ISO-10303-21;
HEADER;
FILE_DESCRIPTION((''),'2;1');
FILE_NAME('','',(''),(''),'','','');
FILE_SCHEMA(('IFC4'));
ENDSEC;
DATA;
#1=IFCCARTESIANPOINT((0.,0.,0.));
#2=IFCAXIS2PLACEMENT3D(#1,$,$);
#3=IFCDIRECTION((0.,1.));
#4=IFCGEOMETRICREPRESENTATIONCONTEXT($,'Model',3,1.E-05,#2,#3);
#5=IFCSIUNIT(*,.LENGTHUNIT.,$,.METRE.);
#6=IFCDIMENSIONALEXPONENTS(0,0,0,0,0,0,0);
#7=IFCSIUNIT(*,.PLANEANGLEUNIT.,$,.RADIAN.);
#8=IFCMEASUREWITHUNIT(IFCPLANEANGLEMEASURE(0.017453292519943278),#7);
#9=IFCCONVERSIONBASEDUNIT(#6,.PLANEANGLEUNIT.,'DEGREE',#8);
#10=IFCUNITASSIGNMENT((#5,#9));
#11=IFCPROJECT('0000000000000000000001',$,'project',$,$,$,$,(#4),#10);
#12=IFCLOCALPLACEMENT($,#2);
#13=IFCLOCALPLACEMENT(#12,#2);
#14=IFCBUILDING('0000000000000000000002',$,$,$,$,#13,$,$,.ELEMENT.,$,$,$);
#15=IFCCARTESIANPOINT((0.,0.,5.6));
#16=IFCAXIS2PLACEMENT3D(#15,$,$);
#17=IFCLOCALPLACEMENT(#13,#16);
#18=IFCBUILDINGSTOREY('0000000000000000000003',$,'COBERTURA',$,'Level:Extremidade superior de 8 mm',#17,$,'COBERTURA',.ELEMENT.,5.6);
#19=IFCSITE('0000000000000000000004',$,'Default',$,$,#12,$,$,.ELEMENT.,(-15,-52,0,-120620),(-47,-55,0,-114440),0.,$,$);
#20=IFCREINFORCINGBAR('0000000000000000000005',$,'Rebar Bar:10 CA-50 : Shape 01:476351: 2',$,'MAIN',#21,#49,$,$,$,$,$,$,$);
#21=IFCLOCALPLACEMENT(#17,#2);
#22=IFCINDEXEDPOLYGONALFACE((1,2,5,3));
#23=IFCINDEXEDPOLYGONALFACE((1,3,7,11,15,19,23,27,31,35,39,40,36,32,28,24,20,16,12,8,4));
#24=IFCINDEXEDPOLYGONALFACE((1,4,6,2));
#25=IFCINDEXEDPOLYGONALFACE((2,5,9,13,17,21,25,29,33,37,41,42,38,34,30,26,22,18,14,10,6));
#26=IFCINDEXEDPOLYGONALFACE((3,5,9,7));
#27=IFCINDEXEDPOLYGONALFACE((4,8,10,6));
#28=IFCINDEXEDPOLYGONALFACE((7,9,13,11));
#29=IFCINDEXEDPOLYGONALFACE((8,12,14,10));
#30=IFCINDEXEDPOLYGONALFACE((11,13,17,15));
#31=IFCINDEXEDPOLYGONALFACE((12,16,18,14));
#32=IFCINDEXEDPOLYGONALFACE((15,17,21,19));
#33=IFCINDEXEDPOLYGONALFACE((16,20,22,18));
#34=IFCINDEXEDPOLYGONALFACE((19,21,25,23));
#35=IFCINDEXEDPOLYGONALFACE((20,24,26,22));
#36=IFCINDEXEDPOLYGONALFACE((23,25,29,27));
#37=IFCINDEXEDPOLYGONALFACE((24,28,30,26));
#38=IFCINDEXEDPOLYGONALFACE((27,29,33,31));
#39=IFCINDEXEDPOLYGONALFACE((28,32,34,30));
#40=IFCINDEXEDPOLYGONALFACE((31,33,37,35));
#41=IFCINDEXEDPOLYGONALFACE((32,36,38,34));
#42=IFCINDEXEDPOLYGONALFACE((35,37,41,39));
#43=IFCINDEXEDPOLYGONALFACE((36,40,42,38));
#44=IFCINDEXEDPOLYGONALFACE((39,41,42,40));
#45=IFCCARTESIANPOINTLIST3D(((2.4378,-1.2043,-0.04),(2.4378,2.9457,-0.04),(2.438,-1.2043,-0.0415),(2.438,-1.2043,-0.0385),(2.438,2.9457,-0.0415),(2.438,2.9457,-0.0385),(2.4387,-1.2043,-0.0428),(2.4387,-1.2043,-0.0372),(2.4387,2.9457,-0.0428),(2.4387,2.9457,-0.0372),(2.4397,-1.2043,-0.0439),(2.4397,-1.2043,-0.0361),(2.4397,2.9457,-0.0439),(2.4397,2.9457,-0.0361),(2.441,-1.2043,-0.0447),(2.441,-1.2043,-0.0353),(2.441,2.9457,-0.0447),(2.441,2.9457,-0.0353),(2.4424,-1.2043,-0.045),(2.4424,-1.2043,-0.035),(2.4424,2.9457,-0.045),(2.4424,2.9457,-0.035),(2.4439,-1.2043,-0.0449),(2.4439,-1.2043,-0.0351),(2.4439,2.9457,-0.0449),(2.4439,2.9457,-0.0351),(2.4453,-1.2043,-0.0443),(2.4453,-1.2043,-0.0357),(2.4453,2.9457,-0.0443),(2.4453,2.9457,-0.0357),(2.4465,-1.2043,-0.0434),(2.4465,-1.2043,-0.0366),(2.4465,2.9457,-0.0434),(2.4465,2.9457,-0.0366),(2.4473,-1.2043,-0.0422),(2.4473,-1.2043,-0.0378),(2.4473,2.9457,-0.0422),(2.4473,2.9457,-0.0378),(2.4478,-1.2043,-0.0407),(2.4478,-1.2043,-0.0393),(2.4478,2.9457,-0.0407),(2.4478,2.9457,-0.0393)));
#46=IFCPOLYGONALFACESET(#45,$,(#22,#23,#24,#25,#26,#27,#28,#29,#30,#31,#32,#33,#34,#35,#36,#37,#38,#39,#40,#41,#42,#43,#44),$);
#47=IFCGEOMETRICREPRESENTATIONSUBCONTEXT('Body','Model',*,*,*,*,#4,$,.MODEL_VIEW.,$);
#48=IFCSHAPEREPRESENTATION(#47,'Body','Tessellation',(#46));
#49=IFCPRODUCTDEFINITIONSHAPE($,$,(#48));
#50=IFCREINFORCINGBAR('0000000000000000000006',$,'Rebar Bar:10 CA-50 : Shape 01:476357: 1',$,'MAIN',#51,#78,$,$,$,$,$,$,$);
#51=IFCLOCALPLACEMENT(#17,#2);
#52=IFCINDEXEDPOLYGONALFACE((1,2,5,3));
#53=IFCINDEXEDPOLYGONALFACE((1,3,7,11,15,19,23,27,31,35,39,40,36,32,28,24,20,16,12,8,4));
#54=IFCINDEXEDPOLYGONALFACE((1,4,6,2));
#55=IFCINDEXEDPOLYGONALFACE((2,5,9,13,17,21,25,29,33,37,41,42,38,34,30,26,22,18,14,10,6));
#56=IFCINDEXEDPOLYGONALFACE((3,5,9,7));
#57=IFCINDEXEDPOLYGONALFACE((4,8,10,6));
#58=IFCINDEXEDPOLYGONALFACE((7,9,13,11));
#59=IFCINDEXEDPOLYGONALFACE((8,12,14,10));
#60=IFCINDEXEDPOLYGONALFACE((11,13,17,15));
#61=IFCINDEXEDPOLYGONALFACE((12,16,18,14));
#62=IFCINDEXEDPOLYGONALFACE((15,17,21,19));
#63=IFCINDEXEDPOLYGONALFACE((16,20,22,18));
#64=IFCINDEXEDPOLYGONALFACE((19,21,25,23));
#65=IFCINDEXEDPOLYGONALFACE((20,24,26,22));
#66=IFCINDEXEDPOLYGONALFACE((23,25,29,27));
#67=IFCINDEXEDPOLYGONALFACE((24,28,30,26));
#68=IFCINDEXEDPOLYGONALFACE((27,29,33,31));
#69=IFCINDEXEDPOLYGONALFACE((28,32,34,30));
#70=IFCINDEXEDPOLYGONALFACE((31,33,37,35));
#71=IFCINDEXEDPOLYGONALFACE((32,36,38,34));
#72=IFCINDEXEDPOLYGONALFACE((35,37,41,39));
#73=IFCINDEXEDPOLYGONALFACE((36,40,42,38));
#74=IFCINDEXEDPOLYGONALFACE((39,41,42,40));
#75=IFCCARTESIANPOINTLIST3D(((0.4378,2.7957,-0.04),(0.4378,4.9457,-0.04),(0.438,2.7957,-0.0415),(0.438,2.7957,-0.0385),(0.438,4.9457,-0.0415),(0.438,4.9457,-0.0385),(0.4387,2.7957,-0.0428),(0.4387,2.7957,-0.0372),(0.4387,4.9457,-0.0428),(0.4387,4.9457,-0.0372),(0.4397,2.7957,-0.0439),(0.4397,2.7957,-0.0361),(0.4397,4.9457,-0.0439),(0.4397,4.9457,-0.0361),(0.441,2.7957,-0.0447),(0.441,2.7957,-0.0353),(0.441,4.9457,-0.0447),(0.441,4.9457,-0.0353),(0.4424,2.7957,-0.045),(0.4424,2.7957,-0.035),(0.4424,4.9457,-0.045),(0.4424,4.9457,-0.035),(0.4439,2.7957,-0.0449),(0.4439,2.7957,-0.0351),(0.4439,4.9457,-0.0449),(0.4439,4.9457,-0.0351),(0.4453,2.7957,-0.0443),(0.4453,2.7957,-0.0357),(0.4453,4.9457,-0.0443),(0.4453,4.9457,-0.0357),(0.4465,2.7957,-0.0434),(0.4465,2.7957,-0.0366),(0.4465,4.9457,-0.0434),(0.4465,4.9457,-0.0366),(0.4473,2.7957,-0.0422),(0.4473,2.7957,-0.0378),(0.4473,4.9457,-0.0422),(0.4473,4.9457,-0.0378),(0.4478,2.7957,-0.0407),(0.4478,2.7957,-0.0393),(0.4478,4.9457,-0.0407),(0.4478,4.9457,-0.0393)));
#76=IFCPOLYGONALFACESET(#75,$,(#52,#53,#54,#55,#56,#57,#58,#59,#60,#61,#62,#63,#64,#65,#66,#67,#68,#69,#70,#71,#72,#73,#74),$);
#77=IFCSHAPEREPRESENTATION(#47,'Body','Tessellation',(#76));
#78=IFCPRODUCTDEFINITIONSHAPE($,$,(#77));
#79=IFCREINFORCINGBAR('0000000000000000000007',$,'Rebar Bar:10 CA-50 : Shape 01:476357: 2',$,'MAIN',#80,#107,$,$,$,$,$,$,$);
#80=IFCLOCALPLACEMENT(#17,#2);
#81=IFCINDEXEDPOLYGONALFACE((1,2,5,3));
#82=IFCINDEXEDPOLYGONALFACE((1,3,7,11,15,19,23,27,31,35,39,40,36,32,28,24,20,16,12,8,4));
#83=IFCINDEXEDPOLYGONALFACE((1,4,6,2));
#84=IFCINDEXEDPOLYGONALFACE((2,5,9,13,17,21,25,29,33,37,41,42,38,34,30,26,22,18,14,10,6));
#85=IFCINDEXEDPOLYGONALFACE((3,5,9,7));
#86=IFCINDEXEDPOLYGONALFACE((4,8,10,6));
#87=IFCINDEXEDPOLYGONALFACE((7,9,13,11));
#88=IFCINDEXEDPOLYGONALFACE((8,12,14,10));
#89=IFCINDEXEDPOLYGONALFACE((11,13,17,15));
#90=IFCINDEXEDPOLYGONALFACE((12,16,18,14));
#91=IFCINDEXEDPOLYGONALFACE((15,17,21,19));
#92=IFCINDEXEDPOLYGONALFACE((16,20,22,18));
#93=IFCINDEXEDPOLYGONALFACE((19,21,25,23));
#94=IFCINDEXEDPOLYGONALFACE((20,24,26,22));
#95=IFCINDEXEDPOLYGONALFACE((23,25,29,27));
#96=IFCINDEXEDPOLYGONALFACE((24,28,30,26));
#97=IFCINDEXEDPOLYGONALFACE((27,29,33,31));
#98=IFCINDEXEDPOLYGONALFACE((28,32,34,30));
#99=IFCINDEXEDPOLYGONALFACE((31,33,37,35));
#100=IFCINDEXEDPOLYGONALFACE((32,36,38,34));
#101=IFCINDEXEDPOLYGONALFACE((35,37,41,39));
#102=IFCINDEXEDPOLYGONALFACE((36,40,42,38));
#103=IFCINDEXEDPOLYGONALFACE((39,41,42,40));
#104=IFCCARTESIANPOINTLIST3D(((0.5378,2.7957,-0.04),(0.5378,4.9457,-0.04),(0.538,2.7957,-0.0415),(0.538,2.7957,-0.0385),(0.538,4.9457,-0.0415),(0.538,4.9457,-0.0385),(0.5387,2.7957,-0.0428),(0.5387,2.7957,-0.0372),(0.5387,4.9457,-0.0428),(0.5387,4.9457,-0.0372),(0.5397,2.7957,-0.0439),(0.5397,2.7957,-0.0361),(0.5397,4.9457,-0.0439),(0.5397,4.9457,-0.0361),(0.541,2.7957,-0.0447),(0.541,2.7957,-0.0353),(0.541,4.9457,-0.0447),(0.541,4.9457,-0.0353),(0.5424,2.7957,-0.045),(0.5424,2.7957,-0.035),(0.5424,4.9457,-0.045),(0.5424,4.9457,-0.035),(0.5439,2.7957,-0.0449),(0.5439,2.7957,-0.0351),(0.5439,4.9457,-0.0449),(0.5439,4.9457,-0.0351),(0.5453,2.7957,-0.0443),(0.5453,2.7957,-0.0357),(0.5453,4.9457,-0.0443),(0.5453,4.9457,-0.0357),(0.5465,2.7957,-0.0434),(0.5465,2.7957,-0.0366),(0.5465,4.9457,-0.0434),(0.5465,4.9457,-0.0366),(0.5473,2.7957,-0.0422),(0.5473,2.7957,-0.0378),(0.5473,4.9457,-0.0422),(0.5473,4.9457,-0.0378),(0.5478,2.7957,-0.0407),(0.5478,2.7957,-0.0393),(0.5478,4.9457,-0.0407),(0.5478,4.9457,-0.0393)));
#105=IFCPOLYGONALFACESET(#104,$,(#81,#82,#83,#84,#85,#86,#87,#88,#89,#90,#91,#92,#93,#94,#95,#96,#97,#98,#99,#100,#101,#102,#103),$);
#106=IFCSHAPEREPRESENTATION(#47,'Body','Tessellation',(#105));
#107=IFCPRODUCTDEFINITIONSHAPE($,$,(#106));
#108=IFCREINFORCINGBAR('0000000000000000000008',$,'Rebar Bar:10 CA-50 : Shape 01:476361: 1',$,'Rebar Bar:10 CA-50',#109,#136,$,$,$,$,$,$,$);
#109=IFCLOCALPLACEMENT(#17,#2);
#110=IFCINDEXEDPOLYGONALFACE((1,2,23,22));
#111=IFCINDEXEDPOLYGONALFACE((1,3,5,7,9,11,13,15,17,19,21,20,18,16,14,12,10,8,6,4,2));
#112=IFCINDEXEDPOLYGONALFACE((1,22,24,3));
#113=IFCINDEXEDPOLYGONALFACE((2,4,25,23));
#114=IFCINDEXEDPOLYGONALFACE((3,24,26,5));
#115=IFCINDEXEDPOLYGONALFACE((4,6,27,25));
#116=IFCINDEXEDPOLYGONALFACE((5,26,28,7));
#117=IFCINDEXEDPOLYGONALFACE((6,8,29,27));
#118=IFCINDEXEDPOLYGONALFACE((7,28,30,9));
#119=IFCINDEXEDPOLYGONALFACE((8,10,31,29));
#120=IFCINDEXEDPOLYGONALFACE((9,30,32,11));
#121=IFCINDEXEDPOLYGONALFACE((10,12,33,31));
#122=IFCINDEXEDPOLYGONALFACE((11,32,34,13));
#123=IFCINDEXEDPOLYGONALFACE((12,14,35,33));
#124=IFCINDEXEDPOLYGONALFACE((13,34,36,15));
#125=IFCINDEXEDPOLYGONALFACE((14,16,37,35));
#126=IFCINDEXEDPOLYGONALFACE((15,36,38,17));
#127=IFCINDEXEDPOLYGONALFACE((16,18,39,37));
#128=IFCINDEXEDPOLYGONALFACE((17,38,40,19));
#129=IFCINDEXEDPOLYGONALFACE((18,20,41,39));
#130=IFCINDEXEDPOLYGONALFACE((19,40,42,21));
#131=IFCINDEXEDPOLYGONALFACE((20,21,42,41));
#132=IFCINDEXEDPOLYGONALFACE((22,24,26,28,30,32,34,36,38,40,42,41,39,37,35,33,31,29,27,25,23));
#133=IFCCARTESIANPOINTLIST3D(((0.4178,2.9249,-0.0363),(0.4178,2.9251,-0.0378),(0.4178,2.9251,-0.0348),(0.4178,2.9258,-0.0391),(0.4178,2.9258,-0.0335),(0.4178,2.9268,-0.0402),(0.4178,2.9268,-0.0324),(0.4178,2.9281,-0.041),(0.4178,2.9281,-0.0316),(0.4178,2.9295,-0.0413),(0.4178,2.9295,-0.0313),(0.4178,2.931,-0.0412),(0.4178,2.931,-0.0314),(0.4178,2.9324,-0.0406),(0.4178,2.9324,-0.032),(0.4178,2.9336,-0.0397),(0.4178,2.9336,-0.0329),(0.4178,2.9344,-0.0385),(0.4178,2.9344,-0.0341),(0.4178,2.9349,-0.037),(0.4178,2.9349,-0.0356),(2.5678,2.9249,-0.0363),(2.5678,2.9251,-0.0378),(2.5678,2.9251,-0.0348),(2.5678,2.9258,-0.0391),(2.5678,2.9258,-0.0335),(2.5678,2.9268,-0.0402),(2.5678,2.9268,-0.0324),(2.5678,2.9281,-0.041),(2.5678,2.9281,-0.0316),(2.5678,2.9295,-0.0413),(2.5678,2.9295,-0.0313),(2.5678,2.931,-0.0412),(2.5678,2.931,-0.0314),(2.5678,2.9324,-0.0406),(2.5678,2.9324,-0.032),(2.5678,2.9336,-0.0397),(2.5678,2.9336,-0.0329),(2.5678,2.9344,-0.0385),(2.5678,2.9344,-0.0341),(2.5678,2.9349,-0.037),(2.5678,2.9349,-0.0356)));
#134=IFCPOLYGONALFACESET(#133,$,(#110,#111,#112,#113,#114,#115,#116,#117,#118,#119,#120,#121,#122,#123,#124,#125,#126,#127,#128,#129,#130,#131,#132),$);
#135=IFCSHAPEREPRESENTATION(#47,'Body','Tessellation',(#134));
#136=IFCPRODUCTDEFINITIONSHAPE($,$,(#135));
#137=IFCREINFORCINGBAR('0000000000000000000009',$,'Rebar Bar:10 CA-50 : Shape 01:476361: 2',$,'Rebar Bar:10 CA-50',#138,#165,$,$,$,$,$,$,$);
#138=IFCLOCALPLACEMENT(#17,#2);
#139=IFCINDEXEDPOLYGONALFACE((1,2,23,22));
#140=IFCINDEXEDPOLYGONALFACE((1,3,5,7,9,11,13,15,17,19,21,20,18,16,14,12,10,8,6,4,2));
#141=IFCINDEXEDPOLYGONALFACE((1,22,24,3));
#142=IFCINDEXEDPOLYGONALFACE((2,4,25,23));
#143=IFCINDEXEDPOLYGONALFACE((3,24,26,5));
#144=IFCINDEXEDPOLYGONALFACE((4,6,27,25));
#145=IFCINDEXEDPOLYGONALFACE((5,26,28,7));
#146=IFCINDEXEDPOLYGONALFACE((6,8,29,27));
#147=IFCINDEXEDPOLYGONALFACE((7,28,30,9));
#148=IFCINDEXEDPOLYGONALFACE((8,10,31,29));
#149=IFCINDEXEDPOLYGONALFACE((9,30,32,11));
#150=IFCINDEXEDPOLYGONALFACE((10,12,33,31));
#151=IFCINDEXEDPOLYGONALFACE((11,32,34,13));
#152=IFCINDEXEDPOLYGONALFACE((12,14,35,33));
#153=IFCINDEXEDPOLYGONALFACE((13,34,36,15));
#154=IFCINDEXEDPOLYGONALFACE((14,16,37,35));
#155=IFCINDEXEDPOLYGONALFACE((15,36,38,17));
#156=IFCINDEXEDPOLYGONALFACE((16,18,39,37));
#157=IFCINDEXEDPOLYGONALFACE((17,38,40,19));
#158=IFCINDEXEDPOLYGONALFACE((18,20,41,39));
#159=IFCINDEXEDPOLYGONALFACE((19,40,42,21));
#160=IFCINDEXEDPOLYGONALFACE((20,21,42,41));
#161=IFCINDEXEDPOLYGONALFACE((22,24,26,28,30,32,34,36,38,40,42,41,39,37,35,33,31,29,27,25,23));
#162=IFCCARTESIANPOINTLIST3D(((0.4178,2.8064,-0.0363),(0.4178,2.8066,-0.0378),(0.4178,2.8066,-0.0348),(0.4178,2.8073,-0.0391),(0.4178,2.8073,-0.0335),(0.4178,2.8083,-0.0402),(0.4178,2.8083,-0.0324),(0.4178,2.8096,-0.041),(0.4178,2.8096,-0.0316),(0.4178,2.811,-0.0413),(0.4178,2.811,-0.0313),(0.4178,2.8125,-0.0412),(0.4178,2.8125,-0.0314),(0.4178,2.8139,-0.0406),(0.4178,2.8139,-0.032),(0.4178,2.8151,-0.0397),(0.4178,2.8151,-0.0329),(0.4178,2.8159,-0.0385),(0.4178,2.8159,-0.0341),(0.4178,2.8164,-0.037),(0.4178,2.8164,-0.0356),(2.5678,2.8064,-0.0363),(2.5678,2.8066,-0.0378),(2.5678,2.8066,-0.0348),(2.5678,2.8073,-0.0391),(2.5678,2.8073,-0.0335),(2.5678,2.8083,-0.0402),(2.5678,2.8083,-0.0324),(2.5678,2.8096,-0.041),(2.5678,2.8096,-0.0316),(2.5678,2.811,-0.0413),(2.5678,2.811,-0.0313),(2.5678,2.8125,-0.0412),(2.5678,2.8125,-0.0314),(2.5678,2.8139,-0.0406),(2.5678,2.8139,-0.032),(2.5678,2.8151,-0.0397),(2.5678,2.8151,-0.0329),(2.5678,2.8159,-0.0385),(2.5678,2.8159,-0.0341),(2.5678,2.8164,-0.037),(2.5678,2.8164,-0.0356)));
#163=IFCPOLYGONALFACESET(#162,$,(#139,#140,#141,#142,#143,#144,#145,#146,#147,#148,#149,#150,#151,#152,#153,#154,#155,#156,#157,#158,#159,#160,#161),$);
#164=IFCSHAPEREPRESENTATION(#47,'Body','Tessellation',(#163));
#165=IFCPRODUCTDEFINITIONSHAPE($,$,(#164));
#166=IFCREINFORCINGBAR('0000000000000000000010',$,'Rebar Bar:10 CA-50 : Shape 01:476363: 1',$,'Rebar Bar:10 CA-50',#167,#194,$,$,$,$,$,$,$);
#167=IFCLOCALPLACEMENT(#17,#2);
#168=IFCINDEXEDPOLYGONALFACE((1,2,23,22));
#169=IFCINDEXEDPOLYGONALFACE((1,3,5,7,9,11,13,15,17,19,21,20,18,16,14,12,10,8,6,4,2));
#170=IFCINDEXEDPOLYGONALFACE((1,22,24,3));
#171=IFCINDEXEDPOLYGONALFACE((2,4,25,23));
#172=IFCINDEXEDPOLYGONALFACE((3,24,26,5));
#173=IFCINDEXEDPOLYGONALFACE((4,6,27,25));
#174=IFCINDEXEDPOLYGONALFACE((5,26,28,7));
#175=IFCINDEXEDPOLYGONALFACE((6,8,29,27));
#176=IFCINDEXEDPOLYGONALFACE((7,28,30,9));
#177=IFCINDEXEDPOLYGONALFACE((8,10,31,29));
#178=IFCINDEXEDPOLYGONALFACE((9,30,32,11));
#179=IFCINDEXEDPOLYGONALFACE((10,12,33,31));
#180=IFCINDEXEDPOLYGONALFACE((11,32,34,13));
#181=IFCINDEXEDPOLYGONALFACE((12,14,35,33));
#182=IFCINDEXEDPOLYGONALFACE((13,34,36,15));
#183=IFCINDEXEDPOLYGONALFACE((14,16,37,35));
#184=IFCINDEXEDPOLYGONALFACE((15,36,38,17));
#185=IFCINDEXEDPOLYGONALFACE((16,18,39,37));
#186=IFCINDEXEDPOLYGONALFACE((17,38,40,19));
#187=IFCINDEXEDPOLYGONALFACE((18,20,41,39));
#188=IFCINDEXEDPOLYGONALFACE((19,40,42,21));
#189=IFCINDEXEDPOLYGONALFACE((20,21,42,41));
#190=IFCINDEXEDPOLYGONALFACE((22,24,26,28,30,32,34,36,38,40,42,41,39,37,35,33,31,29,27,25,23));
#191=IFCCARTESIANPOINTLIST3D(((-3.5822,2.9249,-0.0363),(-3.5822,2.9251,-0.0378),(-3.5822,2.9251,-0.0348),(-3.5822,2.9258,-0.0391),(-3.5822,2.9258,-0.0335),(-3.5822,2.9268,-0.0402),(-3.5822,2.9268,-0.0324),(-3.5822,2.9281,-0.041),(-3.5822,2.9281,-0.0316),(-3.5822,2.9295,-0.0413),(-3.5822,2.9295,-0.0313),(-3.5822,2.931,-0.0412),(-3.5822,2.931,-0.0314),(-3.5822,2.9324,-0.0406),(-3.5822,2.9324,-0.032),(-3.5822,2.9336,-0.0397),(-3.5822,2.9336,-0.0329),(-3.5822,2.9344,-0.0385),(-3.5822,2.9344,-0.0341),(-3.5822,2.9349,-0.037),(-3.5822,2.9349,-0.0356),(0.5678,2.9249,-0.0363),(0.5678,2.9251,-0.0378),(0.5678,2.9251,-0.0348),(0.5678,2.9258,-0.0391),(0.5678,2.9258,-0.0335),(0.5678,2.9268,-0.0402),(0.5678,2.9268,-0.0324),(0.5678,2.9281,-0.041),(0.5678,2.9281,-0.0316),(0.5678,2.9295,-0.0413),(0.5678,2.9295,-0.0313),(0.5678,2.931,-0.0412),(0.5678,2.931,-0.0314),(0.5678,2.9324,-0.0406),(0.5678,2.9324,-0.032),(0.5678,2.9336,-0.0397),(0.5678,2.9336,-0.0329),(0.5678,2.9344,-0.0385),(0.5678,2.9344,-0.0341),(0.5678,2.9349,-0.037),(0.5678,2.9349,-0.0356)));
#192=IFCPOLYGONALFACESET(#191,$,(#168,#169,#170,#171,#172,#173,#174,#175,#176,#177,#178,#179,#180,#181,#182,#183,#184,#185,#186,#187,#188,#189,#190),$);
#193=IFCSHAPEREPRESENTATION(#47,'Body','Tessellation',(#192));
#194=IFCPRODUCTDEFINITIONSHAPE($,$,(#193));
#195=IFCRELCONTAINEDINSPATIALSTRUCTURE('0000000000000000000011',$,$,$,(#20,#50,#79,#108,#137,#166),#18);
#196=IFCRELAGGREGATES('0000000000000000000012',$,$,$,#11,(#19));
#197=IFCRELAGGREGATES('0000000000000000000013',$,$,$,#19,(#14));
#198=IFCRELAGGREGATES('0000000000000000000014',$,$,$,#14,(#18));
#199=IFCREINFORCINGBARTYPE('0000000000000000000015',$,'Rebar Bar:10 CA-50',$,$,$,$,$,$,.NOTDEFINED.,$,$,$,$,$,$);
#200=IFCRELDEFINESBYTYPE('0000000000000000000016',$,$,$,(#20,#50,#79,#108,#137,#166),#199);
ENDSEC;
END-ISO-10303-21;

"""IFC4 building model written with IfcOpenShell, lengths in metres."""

from ifc_helpers import new_model, entity, si_unit, converted_unit, direction, frame, origin, place, context, subcontext, project, spatial, type_object, element, save


model = new_model("IFC4")

# Units and contexts
model_context = context("Model", 3, precision=1e-05, world=origin(), true_north=direction((0.0, 1.0)))
body_context = subcontext(model_context, "Body", "Model", "MODEL_VIEW")
ifc_project = project(units=[si_unit("LENGTHUNIT", "METRE"), converted_unit("PLANEANGLEUNIT", "DEGREE", entity("IfcPlaneAngleMeasure", 0.017453292519943278), si_unit("PLANEANGLEUNIT", "RADIAN"), dimensions=[0, 0, 0, 0, 0, 0, 0])], contexts=[model_context])

# Site, building, storey
site_placement = place(None, origin())
site = spatial("IfcSite", under=ifc_project, at=site_placement, Name="Default", CompositionType="ELEMENT", RefLatitude=(-15, -52, 0, -120620), RefLongitude=(-47, -55, 0, -114440), RefElevation=0.0)
building_placement = place(site_placement, origin())
building = spatial("IfcBuilding", under=site, at=building_placement, CompositionType="ELEMENT")
storey_placement = place(building_placement, frame((0.0, 0.0, 5.6)))
storey = spatial("IfcBuildingStorey", under=building, at=storey_placement, Name="COBERTURA", ObjectType="Level:Extremidade superior de 8 mm", LongName="COBERTURA", CompositionType="ELEMENT", Elevation=5.6)

# Reinforcing bars
reinforcing_bar_type = type_object("IfcReinforcingBarType", Name="Rebar Bar:10 CA-50", PredefinedType="NOTDEFINED")
reinforcing_bar_1_placement = place(storey_placement, origin())
element("IfcReinforcingBar", 1, at=reinforcing_bar_1_placement, inside=storey, type_object=reinforcing_bar_type, Name="Rebar Bar:10 CA-50 : Shape 01:476351: 2", ObjectType="MAIN", context=body_context, shape_type="AdvancedSweptSolid", body=[
    entity("IfcSweptDiskSolid", entity("IfcIndexedPolyCurve", entity("IfcCartesianPointList3D", [[2.4428, 2.9457, -0.04], [2.4428, -1.2043, -0.04]]), None, False), 0.005, None, 0.0, 1.0),
])
reinforcing_bar_2_placement = place(storey_placement, origin())
element("IfcReinforcingBar", 2, at=reinforcing_bar_2_placement, inside=storey, type_object=reinforcing_bar_type, Name="Rebar Bar:10 CA-50 : Shape 01:476357: 1", ObjectType="MAIN", context=body_context, shape_type="AdvancedSweptSolid", body=[
    entity("IfcSweptDiskSolid", entity("IfcIndexedPolyCurve", entity("IfcCartesianPointList3D", [[0.4428, 4.9457, -0.04], [0.4428, 2.7957, -0.04]]), None, False), 0.005, None, 0.0, 1.0),
])
reinforcing_bar_3_placement = place(storey_placement, origin())
element("IfcReinforcingBar", 3, at=reinforcing_bar_3_placement, inside=storey, type_object=reinforcing_bar_type, Name="Rebar Bar:10 CA-50 : Shape 01:476357: 2", ObjectType="MAIN", context=body_context, shape_type="AdvancedSweptSolid", body=[
    entity("IfcSweptDiskSolid", entity("IfcIndexedPolyCurve", entity("IfcCartesianPointList3D", [[0.5428, 4.9457, -0.04], [0.5428, 2.7957, -0.04]]), None, False), 0.005, None, 0.0, 1.0),
])
reinforcing_bar_4_placement = place(storey_placement, origin())
element("IfcReinforcingBar", 4, at=reinforcing_bar_4_placement, inside=storey, type_object=reinforcing_bar_type, Name="Rebar Bar:10 CA-50 : Shape 01:476361: 1", ObjectType="Rebar Bar:10 CA-50", context=body_context, shape_type="AdvancedSweptSolid", body=[
    entity("IfcSweptDiskSolid", entity("IfcIndexedPolyCurve", entity("IfcCartesianPointList3D", [[2.5678, 2.9299, -0.0363], [0.4178, 2.9299, -0.0363]]), None, False), 0.005, None, 0.0, 1.0),
])
reinforcing_bar_5_placement = place(storey_placement, origin())
element("IfcReinforcingBar", 5, at=reinforcing_bar_5_placement, inside=storey, type_object=reinforcing_bar_type, Name="Rebar Bar:10 CA-50 : Shape 01:476361: 2", ObjectType="Rebar Bar:10 CA-50", context=body_context, shape_type="AdvancedSweptSolid", body=[
    entity("IfcSweptDiskSolid", entity("IfcIndexedPolyCurve", entity("IfcCartesianPointList3D", [[2.5678, 2.8114, -0.0363], [0.4178, 2.8114, -0.0363]]), None, False), 0.005, None, 0.0, 1.0),
])
reinforcing_bar_6_placement = place(storey_placement, origin())
element("IfcReinforcingBar", 6, at=reinforcing_bar_6_placement, inside=storey, type_object=reinforcing_bar_type, Name="Rebar Bar:10 CA-50 : Shape 01:476363: 1", ObjectType="Rebar Bar:10 CA-50", context=body_context, shape_type="AdvancedSweptSolid", body=[
    entity("IfcSweptDiskSolid", entity("IfcIndexedPolyCurve", entity("IfcCartesianPointList3D", [[0.5678, 2.9299, -0.0363], [-3.5822, 2.9299, -0.0363]]), None, False), 0.005, None, 0.0, 1.0),
])

save(model, "model.ifc")
